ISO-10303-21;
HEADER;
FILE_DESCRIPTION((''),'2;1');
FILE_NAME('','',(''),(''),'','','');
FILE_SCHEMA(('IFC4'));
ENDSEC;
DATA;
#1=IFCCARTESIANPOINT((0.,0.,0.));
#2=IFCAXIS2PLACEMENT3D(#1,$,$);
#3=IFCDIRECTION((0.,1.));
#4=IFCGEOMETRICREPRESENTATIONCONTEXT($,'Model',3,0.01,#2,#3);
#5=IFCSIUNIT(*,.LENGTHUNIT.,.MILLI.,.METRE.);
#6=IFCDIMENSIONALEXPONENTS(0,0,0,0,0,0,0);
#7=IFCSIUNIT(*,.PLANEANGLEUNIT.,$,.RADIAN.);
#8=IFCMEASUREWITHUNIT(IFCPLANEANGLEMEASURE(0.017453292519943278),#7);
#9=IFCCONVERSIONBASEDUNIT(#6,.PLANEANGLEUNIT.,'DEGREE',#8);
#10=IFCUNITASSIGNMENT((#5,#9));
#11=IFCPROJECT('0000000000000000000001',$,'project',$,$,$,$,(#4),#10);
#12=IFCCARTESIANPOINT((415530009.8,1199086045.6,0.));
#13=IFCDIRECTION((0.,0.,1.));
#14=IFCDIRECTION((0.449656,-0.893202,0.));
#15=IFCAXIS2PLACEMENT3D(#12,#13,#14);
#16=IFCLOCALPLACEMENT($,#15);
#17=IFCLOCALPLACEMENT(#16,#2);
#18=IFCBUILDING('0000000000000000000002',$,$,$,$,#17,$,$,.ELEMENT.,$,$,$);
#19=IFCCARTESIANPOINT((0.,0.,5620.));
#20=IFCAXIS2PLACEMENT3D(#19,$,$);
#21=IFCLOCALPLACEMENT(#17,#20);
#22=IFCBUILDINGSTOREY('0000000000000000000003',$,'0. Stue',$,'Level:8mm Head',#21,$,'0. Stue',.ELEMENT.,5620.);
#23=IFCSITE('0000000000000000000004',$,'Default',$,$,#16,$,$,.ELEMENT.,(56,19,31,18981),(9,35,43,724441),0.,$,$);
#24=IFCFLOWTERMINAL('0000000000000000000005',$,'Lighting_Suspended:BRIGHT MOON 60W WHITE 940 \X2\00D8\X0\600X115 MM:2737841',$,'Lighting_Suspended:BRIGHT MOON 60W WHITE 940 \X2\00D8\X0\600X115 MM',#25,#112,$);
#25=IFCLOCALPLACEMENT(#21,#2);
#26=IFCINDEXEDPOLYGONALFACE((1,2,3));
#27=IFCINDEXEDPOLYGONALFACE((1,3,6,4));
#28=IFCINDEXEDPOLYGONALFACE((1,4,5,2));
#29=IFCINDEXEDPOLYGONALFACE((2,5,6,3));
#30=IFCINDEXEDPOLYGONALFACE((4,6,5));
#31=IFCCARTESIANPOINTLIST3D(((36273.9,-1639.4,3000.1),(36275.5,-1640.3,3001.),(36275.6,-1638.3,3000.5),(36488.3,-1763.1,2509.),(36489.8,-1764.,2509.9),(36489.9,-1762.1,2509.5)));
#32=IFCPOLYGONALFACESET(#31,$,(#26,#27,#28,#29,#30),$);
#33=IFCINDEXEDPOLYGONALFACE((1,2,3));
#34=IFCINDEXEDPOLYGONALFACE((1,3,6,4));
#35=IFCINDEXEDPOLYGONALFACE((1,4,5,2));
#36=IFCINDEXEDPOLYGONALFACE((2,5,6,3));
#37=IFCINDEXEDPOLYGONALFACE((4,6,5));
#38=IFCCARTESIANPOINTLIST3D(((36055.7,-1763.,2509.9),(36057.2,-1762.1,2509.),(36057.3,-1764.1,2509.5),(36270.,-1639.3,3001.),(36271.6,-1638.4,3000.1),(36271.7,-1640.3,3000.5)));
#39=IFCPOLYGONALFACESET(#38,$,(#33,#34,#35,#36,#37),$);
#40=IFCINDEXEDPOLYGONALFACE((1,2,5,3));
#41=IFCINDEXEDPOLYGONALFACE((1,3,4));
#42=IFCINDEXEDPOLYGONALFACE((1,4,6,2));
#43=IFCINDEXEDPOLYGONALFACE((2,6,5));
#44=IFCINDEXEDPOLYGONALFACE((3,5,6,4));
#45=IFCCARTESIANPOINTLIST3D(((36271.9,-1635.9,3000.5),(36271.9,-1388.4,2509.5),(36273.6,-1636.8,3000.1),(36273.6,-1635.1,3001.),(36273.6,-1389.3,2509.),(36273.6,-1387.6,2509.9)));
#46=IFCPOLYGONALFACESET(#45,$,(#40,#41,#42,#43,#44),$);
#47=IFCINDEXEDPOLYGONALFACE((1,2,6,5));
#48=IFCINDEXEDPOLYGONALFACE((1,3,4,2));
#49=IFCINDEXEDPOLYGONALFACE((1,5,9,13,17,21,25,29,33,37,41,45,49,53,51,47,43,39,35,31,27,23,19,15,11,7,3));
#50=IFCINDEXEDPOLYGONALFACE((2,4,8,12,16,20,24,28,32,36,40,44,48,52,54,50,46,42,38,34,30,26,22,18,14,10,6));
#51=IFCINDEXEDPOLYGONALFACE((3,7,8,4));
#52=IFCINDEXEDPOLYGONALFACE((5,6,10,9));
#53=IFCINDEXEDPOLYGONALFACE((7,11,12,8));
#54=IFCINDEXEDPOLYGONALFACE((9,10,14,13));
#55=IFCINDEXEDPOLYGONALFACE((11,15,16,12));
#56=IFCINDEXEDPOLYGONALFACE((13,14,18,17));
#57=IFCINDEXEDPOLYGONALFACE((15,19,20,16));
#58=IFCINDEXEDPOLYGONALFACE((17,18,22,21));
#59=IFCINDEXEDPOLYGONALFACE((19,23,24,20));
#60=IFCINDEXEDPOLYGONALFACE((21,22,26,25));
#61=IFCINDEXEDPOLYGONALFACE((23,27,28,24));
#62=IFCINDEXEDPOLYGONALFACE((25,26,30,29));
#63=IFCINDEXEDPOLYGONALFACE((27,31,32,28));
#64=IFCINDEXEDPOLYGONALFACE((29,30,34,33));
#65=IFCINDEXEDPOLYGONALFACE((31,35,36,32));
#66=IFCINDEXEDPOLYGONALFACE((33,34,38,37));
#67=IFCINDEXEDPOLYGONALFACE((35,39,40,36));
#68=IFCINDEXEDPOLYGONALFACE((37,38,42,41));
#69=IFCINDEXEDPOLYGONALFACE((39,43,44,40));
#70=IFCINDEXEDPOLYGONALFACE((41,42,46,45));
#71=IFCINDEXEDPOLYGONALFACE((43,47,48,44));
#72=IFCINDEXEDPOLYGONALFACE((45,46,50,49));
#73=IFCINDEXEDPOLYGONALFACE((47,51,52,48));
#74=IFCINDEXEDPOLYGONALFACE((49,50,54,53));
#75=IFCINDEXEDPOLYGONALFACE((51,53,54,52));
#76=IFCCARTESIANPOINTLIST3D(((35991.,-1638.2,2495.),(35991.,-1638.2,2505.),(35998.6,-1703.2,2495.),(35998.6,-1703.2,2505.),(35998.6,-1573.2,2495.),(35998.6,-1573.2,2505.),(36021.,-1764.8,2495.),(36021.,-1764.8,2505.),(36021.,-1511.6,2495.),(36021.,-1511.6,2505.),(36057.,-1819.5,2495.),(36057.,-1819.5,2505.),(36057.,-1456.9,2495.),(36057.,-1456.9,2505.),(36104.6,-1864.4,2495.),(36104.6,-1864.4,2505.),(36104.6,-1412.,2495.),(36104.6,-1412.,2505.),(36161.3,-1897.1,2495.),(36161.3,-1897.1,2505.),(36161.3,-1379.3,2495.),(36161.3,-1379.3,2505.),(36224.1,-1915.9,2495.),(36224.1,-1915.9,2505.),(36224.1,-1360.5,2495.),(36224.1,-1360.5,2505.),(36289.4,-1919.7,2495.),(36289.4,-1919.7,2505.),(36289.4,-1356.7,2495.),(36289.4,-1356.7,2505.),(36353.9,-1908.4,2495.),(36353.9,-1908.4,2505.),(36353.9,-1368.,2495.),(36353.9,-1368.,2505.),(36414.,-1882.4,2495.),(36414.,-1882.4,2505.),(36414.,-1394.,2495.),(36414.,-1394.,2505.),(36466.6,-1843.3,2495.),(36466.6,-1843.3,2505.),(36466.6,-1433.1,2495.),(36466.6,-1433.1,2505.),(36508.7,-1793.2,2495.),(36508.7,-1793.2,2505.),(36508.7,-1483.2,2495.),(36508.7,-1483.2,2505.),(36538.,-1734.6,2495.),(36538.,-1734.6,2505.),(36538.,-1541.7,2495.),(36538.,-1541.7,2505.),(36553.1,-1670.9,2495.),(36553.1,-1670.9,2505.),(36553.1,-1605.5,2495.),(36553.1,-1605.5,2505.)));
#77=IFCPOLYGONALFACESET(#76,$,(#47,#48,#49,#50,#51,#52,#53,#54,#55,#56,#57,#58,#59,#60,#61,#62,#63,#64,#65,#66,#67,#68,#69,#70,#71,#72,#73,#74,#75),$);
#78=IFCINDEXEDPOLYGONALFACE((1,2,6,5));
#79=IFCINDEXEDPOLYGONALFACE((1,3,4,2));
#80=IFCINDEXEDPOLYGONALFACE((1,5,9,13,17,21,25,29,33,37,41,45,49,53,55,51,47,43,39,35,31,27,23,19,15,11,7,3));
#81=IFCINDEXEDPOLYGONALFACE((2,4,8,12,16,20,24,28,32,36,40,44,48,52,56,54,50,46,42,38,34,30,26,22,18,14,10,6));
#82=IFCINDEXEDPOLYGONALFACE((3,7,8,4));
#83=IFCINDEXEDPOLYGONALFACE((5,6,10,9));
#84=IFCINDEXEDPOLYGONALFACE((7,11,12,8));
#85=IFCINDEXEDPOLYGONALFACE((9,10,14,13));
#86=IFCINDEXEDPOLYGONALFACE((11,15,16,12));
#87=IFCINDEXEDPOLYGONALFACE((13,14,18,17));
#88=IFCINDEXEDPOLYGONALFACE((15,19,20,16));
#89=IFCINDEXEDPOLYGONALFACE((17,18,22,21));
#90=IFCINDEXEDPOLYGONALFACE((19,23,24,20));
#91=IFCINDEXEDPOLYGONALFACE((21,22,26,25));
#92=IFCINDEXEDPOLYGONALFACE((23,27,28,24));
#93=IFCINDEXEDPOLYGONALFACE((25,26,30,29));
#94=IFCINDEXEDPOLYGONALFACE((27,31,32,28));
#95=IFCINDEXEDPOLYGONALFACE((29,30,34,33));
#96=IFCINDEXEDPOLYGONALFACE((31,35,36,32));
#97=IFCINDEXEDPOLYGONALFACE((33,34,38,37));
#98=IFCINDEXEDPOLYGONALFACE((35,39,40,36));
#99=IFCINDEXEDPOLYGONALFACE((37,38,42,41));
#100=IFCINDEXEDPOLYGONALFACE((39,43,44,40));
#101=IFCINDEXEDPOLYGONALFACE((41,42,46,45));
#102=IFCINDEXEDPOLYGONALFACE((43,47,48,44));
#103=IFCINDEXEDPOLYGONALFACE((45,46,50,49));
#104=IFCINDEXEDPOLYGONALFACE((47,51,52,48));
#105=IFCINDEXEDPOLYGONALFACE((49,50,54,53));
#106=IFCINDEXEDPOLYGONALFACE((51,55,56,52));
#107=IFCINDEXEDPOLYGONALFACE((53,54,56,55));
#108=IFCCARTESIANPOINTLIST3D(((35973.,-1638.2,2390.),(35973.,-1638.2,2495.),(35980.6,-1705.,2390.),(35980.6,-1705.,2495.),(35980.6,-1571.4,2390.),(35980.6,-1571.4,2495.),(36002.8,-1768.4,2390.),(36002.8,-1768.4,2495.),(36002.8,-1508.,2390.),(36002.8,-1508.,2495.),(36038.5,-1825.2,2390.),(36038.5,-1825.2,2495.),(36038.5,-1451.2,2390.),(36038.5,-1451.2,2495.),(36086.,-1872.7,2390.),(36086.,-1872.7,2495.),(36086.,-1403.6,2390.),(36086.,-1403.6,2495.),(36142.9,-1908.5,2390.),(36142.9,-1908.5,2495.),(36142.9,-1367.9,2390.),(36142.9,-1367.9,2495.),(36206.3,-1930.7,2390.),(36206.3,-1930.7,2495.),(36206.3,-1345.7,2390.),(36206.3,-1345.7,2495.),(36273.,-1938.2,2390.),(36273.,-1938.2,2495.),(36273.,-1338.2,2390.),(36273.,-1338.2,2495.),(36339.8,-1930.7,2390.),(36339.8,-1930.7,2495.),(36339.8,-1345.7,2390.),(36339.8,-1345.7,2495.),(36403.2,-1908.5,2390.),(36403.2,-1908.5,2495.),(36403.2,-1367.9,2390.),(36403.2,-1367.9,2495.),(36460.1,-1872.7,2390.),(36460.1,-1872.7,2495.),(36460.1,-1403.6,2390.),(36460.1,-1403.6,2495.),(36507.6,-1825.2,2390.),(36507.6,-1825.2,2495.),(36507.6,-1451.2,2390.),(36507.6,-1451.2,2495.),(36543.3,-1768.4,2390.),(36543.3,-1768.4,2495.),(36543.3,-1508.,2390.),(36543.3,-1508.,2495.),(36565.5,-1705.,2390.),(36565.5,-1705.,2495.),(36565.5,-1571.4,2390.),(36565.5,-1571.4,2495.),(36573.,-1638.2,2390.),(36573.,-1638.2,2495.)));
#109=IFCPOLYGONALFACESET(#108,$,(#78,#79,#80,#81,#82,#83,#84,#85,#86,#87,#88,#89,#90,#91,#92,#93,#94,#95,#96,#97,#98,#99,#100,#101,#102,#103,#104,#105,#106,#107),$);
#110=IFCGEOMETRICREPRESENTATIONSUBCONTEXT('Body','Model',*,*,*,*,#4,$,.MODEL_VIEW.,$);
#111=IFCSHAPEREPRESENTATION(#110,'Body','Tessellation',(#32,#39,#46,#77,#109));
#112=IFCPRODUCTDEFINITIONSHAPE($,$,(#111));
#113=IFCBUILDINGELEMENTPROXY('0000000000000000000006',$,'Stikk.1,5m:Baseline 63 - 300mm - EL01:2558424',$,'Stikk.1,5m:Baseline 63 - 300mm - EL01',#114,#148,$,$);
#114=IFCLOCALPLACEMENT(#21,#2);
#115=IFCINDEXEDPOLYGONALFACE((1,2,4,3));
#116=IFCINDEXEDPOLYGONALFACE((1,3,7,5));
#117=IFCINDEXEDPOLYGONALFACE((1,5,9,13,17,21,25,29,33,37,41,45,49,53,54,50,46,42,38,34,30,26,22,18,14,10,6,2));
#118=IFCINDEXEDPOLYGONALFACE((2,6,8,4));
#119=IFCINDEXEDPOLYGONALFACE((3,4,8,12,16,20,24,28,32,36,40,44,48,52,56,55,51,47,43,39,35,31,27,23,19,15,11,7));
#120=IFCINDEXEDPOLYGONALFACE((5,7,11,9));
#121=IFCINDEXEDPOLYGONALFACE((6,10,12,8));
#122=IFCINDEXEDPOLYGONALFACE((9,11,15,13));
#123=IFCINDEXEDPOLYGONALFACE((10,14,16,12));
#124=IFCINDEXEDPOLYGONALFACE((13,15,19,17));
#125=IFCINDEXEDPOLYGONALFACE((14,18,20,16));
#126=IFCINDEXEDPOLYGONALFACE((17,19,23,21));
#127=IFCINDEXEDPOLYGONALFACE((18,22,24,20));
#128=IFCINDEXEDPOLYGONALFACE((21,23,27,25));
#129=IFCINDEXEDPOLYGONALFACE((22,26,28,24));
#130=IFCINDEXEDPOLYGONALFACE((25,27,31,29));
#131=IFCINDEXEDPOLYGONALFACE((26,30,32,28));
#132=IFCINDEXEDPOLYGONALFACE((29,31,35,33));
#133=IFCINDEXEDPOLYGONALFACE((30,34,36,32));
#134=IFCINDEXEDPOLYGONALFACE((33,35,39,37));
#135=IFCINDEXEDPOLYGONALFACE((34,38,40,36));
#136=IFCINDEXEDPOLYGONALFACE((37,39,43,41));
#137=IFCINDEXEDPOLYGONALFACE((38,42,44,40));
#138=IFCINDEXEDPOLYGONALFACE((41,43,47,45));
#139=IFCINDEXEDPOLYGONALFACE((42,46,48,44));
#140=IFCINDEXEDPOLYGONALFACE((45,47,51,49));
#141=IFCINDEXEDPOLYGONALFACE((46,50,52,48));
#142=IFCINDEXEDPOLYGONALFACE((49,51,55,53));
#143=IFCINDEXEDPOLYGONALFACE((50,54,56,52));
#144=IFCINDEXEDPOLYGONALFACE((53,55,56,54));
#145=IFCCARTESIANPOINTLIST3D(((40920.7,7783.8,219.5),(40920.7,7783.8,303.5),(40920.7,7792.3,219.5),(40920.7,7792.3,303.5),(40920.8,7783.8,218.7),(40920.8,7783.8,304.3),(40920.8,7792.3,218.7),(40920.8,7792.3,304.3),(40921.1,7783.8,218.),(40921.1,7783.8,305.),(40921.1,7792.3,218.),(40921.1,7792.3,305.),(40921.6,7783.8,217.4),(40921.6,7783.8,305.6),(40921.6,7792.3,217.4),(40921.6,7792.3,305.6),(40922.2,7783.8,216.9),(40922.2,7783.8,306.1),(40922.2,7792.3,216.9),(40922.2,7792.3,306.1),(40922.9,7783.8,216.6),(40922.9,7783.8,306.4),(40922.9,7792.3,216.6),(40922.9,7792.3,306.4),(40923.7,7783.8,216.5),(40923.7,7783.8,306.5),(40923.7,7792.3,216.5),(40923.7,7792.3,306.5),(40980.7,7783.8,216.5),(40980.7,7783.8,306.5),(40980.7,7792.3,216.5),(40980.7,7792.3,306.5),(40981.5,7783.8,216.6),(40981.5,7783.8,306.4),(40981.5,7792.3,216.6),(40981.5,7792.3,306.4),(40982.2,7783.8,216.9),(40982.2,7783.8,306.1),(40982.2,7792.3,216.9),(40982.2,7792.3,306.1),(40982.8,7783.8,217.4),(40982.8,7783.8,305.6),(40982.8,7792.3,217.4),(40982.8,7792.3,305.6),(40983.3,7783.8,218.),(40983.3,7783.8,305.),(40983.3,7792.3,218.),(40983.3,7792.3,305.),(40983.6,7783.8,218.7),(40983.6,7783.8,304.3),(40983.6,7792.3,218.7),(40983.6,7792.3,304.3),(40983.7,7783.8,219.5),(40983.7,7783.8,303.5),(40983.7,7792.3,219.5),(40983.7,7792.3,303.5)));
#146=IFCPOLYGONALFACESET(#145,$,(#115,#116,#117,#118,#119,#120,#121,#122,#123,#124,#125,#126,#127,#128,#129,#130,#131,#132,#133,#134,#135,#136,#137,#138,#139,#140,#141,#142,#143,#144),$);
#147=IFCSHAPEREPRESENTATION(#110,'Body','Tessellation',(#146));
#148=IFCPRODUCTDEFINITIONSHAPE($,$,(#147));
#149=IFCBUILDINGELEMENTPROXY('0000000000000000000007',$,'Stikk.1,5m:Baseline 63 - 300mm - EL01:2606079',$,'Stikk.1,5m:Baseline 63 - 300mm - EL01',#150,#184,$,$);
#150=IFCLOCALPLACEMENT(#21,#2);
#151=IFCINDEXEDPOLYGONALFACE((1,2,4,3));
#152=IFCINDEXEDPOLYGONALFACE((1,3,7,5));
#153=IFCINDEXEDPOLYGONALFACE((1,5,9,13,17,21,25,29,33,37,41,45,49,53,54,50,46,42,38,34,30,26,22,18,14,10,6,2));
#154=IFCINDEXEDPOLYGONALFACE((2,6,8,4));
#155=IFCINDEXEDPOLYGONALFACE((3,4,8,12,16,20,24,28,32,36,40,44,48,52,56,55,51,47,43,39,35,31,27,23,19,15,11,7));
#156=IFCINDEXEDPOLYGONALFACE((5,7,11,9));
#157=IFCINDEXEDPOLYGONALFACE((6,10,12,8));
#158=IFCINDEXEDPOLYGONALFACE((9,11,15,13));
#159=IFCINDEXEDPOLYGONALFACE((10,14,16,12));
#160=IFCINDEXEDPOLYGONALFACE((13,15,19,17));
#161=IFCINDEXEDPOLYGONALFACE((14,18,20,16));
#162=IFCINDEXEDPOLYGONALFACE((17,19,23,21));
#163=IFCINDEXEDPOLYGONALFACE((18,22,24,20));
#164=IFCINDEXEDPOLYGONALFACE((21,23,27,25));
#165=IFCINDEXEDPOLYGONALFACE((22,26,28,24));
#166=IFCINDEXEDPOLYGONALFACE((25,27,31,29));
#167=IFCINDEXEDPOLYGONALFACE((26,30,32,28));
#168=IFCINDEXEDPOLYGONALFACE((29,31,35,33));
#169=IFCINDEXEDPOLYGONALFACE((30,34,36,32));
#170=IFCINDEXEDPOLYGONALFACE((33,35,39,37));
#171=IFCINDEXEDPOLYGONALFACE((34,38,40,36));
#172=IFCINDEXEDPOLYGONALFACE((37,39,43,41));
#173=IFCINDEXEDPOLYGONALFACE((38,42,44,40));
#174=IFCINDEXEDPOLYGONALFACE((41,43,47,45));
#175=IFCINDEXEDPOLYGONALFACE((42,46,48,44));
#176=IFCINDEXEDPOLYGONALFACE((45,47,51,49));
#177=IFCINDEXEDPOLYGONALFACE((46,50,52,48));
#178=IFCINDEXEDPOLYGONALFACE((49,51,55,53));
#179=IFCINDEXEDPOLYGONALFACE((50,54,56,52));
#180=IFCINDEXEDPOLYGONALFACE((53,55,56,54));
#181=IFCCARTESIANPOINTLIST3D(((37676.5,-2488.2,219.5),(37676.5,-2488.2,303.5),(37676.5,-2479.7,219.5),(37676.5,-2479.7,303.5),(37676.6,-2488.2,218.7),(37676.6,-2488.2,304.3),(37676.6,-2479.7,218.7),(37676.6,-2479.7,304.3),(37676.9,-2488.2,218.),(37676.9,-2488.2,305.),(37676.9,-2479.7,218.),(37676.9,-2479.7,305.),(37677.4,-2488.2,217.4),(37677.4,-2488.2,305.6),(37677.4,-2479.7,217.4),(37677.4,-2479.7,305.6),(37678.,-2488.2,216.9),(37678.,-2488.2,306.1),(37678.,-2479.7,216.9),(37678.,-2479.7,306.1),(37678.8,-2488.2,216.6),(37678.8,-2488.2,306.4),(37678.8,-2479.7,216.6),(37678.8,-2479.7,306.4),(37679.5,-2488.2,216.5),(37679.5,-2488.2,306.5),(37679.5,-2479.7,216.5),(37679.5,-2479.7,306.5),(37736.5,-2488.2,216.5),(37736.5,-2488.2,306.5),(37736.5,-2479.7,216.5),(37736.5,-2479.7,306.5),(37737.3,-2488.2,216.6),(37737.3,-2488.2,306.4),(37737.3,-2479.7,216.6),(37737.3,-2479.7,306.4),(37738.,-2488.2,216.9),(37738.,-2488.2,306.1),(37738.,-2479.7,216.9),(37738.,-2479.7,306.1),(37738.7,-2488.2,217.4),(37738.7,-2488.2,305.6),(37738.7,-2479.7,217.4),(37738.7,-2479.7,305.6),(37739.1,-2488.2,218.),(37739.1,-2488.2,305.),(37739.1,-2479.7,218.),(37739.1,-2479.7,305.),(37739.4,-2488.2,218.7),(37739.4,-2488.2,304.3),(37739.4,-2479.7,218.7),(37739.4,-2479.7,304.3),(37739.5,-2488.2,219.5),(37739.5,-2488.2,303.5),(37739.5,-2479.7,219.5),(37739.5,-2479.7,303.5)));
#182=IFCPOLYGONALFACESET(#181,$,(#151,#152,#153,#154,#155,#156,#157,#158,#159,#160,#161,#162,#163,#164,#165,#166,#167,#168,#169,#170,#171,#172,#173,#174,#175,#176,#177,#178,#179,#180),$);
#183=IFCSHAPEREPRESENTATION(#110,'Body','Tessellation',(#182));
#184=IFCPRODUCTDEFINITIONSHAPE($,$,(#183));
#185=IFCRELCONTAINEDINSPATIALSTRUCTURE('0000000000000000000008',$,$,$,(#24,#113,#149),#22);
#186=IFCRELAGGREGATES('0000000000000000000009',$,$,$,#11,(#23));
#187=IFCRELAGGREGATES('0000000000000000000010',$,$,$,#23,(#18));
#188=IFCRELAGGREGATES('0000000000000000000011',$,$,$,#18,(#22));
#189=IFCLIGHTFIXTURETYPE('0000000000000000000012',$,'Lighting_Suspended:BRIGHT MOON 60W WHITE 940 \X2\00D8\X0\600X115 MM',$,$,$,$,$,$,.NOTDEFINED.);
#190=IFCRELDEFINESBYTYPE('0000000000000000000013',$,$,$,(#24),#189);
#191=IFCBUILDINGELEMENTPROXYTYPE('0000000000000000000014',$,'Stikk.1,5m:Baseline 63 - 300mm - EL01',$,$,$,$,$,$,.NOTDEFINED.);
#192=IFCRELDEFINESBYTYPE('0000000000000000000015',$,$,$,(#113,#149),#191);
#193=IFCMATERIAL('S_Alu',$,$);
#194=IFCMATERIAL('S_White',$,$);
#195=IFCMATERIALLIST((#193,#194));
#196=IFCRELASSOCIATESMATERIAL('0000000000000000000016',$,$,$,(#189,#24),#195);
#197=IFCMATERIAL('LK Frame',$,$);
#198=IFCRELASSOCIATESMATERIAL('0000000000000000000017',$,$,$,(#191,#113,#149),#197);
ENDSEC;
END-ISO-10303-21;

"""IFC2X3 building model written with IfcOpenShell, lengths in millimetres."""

from ifc_helpers import new_model, entity, si_unit, converted_unit, direction, frame, frame_2d, origin, place, context, subcontext, project, spatial, polyline, circle_curve, parameter, trimmed, segment, composite_curve, circle, outline, extrude, source, transform, mapped, material, material_list, type_object, type_shapes, element, save


model = new_model("IFC2X3")

# Units and contexts
model_context = context("Model", 3, precision=0.01, world=origin(), true_north=direction((0.0, 1.0)))
body_context = subcontext(model_context, "Body", "Model", "MODEL_VIEW")
ifc_project = project(units=[si_unit("LENGTHUNIT", "METRE", prefix="MILLI"), converted_unit("PLANEANGLEUNIT", "DEGREE", entity("IfcPlaneAngleMeasure", 0.017453292519943278), si_unit("PLANEANGLEUNIT", "RADIAN"), dimensions=[0, 0, 0, 0, 0, 0, 0])], contexts=[model_context])

# Site, building, storey
site_placement = place(None, frame((415530009.8, 1199086045.6, 0.0), z_axis=(0.0, 0.0, 1.0), x_axis=(0.449656, -0.893202, 0.0)))
site = spatial("IfcSite", under=ifc_project, at=site_placement, Name="Default", CompositionType="ELEMENT", RefLatitude=(56, 19, 31, 18981), RefLongitude=(9, 35, 43, 724441), RefElevation=0.0)
building_placement = place(site_placement, origin())
building = spatial("IfcBuilding", under=site, at=building_placement, CompositionType="ELEMENT")
storey_placement = place(building_placement, frame((0.0, 0.0, 5620.0)))
storey = spatial("IfcBuildingStorey", under=building, at=storey_placement, Name="0. Stue", ObjectType="Level:8mm Head", LongName="0. Stue", CompositionType="ELEMENT", Elevation=5620.0)

# Flow terminal
ifc_material_1 = material(Name="S_White")
ifc_material_2 = material(Name="S_Alu")
ifc_material_list = material_list([ifc_material_2, ifc_material_1])
light_fixture_type_1 = type_object("IfcLightFixtureType", Name="Lighting_Suspended:BRIGHT MOON 60W WHITE 940 Ø600X115 MM", PredefinedType="NOTDEFINED", material=ifc_material_list)
shared_shape_1 = source(origin(), body_context, "Body", "SweptSolid", [
    extrude(outline(polyline([(-1.0, -0.6), (1.0, -0.6), (0.0, 1.2), (-1.0, -0.6)])), frame((-216.3, 124.9, -495.5), z_axis=(0.389771, -0.225034, 0.892994), x_axis=(-0.773355, 0.446497, 0.450069)), (0.0, 0.0, 1.0), 549.9),
    extrude(outline(polyline([(-1.0, -0.6), (1.0, -0.6), (0.0, 1.2), (-1.0, -0.6)])), frame((216.3, 124.9, -495.5), z_axis=(-0.389771, -0.225034, 0.892994), x_axis=(0.773355, 0.446497, 0.450069)), (0.0, 0.0, 1.0), 549.9),
    extrude(outline(polyline([(-1.0, -0.6), (1.0, -0.6), (0.0, 1.2), (-1.0, -0.6)])), frame((0.0, -249.7, -495.5), z_axis=(0.0, 0.450069, 0.892994), x_axis=(0.0, -0.892994, 0.450069)), (0.0, 0.0, 1.0), 549.9),
    extrude(circle(Radius=282.0, at=frame_2d((0.0, 0.0), x_axis=(1.0, 0.0))), frame((0.0, 0.0, -510.0)), (0.0, 0.0, 1.0), 10.0),
    extrude(circle(Radius=300.0, at=frame_2d((0.0, 0.0), x_axis=(1.0, 0.0))), frame((0.0, 0.0, -615.0)), (0.0, 0.0, 1.0), 105.0),
])
type_shapes(light_fixture_type_1, [shared_shape_1])
for number, where, z_axis, x_axis, name in (
    (1, (36273.0, -1638.2, 3005.0), (0.0, 0.0, 1.0), (-1.0, 0.0, 0.0), "Lighting_Suspended:BRIGHT MOON 60W WHITE 940 Ø600X115 MM:2737841"),
):
    element("IfcFlowTerminal", number, at=place(storey_placement, frame(where, z_axis=z_axis, x_axis=x_axis)), inside=storey, type_object=light_fixture_type_1, material=ifc_material_list, Name=name, ObjectType="Lighting_Suspended:BRIGHT MOON 60W WHITE 940 Ø600X115 MM", context=body_context, shape_type="MappedRepresentation", body=[
        mapped(shared_shape_1, transform((0.0, 0.0, 0.0), scale=1.0)),
    ])

# Building element proxies
ifc_material_3 = material(Name="LK Frame")
building_element_proxy_type_1 = type_object("IfcBuildingElementProxyType", Name="Stikk.1,5m:Baseline 63 - 300mm - EL01", PredefinedType="NOTDEFINED", material=ifc_material_3)
shared_shape_2 = source(origin(), body_context, "Body", "SweptSolid", [
    extrude(outline(composite_curve([segment(polyline([(-42.0, -31.5), (42.0, -31.5)]), True, "CONTINUOUS"), segment(trimmed(circle_curve(frame_2d((42.0, -28.5), x_axis=(-1.0, 0.0)), 3.0), [parameter(90.0)], [parameter(180.0)], True, "PARAMETER"), True, "CONTINUOUS"), segment(polyline([(45.0, -28.5), (45.0, 28.5)]), True, "CONTINUOUS"), segment(trimmed(circle_curve(frame_2d((42.0, 28.5), x_axis=(-1.0, 0.0)), 3.0), [parameter(180.0)], [parameter(270.0)], True, "PARAMETER"), True, "CONTINUOUS"), segment(polyline([(42.0, 31.5), (-42.0, 31.5)]), True, "CONTINUOUS"), segment(trimmed(circle_curve(frame_2d((-42.0, 28.5), x_axis=(1.0, 0.0)), 3.0), [parameter(90.0)], [parameter(180.0)], True, "PARAMETER"), True, "CONTINUOUS"), segment(polyline([(-45.0, 28.5), (-45.0, -28.5)]), True, "CONTINUOUS"), segment(trimmed(circle_curve(frame_2d((-42.0, -28.5), x_axis=(1.0, 0.0)), 3.0), [parameter(180.0)], [parameter(270.0)], True, "PARAMETER"), True, "CONTINUOUS")], self_intersect=False)), frame((0.0, -38.5, 0.0), z_axis=(0.0, 0.0, 1.0), x_axis=(0.0, 1.0, 0.0)), (0.0, 0.0, 1.0), 8.5),
])
type_shapes(building_element_proxy_type_1, [shared_shape_2])
for number, where, z_axis, x_axis, name in (
    (2, (40952.2, 7783.8, 300.0), (0.0, 1.0, 0.0), (-1.0, 0.0, 0.0), "Stikk.1,5m:Baseline 63 - 300mm - EL01:2558424"),
    (3, (37708.0, -2488.2, 300.0), (0.0, 1.0, 0.0), (-1.0, 0.0, 0.0), "Stikk.1,5m:Baseline 63 - 300mm - EL01:2606079"),
):
    element("IfcBuildingElementProxy", number, at=place(storey_placement, frame(where, z_axis=z_axis, x_axis=x_axis)), inside=storey, type_object=building_element_proxy_type_1, material=ifc_material_3, Name=name, ObjectType="Stikk.1,5m:Baseline 63 - 300mm - EL01", context=body_context, shape_type="MappedRepresentation", body=[
        mapped(shared_shape_2, transform((0.0, 0.0, 0.0), scale=1.0)),
    ])

save(model, "model.ifc")
